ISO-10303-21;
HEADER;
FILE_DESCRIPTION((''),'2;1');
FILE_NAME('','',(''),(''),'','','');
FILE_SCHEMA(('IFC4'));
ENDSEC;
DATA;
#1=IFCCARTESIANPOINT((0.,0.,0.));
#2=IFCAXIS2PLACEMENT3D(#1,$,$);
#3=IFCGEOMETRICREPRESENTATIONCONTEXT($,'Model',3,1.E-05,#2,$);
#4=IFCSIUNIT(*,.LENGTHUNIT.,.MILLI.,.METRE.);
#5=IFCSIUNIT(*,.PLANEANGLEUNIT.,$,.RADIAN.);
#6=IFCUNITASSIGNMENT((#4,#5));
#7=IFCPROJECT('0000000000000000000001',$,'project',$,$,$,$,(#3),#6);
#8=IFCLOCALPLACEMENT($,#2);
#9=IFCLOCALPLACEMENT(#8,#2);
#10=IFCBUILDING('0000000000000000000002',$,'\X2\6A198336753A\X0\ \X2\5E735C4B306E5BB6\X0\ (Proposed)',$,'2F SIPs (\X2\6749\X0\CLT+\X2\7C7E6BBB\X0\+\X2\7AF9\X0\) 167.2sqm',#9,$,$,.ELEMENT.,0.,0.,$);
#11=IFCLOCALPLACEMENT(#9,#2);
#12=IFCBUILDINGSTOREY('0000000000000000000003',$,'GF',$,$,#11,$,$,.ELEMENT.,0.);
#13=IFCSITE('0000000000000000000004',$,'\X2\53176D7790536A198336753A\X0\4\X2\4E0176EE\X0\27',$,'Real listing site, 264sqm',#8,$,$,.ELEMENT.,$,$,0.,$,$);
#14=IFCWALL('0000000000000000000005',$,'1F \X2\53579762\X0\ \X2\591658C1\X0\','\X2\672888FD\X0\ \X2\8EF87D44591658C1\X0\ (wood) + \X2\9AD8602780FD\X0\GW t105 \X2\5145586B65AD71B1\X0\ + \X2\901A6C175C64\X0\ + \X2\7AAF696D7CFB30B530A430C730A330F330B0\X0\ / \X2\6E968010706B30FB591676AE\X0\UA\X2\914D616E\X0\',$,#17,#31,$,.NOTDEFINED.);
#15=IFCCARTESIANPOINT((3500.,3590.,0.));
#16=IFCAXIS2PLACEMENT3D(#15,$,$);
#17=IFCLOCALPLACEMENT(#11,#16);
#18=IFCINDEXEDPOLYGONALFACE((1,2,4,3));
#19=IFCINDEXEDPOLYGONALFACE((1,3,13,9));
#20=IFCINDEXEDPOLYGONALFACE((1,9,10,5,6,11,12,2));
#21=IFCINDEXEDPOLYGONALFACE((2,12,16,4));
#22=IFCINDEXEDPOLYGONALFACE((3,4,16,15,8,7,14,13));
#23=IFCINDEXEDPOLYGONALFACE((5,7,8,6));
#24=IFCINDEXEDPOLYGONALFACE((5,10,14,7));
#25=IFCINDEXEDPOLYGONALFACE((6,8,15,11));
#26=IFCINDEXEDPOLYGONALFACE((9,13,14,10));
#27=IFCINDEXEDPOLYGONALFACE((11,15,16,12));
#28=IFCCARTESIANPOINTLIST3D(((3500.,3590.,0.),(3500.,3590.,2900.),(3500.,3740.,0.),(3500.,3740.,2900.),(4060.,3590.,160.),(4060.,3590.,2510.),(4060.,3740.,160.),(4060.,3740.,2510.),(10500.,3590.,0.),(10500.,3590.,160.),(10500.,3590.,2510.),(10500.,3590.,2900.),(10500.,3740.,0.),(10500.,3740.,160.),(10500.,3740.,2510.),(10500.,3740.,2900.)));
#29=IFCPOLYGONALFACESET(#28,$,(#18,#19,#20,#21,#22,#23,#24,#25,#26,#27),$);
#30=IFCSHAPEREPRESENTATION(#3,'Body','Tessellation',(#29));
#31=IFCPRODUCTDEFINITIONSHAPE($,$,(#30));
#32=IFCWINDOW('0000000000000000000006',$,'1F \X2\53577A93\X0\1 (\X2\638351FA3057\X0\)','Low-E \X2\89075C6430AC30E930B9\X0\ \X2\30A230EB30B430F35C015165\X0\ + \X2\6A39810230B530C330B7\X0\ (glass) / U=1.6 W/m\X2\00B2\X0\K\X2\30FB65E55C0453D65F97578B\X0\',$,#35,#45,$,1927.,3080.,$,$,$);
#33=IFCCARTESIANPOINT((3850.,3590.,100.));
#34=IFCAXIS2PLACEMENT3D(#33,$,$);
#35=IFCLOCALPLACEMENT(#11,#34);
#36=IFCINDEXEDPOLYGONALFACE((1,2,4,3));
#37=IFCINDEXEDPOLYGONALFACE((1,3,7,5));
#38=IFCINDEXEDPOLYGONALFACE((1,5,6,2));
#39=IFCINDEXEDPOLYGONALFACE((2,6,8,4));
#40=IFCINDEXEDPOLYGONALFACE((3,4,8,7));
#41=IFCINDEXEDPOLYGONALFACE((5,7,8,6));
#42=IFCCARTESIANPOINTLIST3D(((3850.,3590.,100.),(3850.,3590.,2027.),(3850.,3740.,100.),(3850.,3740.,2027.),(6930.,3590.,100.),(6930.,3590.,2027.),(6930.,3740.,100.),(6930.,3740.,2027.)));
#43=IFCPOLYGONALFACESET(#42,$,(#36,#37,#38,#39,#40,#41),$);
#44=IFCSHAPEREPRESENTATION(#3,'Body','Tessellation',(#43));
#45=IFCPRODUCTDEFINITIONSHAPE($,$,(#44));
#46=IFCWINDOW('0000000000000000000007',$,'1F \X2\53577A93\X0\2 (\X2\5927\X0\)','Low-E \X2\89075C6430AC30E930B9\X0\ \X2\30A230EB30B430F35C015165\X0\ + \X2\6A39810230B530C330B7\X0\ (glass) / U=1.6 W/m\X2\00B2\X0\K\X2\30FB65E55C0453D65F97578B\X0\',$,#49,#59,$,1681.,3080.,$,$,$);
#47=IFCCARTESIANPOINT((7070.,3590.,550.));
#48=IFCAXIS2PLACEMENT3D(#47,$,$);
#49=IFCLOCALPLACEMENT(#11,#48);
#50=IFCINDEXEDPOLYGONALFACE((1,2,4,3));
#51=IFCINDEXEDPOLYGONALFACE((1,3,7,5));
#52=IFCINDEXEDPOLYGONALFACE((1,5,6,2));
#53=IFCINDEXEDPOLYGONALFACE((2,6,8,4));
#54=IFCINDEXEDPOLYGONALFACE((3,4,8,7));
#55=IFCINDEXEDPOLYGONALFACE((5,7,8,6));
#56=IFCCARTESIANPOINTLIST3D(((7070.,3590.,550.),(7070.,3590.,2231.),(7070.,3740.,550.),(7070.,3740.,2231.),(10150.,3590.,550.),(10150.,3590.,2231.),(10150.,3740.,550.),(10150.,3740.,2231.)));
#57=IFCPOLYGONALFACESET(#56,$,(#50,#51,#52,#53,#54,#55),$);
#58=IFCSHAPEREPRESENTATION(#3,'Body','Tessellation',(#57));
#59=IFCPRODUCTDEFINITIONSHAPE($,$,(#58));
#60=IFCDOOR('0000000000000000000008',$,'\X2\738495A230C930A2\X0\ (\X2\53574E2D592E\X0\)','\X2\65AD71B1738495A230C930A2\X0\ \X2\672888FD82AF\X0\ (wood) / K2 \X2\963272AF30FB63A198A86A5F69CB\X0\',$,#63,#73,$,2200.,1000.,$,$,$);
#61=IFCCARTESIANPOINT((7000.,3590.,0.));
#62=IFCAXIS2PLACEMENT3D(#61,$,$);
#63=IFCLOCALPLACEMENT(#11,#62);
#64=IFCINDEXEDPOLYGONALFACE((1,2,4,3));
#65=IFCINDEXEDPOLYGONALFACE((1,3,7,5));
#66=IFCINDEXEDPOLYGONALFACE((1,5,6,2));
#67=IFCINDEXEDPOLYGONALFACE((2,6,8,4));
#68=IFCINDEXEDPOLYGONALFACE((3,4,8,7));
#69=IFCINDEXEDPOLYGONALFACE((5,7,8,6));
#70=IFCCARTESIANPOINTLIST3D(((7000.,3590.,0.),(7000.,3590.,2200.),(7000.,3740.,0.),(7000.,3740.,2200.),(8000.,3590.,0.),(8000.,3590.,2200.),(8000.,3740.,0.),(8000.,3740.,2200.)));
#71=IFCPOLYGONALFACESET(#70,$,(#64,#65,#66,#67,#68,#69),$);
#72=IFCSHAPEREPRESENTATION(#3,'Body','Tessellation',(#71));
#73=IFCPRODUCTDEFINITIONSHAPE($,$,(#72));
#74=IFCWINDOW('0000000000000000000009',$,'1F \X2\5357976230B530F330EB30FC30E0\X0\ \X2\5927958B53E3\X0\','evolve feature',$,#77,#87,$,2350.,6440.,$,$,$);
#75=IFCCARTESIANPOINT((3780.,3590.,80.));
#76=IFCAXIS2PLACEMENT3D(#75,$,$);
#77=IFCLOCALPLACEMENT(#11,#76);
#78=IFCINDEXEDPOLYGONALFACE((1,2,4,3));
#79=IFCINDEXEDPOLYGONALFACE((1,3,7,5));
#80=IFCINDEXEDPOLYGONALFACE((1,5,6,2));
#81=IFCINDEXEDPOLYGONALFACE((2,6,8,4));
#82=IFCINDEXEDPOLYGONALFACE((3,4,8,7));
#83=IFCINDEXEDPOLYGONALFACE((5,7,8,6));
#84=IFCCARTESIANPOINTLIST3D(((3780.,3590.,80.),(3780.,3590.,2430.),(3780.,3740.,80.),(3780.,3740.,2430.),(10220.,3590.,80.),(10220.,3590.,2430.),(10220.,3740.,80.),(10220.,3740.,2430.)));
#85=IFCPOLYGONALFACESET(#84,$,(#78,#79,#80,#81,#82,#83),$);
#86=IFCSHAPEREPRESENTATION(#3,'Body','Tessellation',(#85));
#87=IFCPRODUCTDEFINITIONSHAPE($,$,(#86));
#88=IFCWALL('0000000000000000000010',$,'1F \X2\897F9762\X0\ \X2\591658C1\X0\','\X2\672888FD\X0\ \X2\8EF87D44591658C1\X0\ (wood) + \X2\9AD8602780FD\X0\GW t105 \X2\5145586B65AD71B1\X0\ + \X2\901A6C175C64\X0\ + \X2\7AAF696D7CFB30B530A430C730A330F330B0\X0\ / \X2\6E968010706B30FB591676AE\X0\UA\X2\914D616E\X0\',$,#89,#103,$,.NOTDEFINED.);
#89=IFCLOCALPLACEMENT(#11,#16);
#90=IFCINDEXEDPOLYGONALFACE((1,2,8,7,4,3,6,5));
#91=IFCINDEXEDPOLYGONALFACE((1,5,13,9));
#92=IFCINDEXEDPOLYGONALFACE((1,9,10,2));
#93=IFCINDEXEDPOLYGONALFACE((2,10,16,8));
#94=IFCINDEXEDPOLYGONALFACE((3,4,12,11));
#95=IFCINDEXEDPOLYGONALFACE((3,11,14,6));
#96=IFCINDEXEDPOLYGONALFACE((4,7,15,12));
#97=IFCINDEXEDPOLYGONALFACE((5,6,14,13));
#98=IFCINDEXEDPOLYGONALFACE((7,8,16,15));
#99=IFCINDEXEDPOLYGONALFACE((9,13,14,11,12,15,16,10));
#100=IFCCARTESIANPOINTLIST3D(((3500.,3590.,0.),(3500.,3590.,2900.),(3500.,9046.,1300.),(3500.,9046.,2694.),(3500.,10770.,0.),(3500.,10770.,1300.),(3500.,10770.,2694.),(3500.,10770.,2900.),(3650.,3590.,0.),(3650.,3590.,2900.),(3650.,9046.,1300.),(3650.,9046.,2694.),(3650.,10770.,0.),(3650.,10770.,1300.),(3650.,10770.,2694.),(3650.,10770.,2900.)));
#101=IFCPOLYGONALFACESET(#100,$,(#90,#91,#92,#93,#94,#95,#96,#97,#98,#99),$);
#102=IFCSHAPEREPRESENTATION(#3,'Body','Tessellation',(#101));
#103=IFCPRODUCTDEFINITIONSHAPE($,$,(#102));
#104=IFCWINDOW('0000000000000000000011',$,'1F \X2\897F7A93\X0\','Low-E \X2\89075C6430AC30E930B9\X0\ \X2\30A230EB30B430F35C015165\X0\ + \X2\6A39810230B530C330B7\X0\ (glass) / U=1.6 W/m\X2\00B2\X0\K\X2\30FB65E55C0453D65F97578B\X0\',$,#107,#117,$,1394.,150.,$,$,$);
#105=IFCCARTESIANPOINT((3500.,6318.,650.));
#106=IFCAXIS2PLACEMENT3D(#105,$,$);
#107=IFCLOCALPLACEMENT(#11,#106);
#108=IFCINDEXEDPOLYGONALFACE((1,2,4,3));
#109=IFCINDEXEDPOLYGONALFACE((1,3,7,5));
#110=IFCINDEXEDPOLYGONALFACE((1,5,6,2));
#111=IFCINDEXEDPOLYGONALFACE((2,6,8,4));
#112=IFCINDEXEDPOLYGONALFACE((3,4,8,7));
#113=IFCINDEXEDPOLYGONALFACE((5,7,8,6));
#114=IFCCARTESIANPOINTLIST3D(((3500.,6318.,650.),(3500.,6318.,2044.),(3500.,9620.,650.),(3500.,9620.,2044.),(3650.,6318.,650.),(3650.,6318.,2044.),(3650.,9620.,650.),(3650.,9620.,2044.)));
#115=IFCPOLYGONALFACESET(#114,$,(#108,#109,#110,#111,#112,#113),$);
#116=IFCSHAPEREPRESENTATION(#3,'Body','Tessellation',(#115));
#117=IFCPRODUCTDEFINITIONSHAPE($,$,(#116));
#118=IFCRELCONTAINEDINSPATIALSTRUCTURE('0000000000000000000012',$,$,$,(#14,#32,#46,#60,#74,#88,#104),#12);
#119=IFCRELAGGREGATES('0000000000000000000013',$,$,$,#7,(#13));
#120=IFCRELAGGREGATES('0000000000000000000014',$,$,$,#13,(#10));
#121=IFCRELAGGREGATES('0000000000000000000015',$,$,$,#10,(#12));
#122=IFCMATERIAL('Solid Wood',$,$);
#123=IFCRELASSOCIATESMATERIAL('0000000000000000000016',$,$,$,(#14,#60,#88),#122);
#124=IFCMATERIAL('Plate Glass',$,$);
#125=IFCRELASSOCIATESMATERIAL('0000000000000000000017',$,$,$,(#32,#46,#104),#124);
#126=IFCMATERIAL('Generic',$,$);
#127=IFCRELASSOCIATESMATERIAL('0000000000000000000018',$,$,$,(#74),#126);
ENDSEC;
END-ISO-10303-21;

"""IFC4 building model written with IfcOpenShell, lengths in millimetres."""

from ifc_helpers import new_model, si_unit, frame, frame_2d, origin, place, context, project, spatial, rectangle, extrude, material, element, fill, save


model = new_model("IFC4")

# Units and contexts
model_context = context("Model", 3, precision=1e-05, world=origin())
ifc_project = project(units=[si_unit("LENGTHUNIT", "METRE", prefix="MILLI"), si_unit("PLANEANGLEUNIT", "RADIAN")], contexts=[model_context])

# Site, building, storey
site_placement = place(None, origin())
site = spatial("IfcSite", under=ifc_project, at=site_placement, Name="北海道標茶町4丁目27", ObjectType="Real listing site, 264sqm", CompositionType="ELEMENT", RefElevation=0.0)
building_placement = place(site_placement, origin())
building = spatial("IfcBuilding", under=site, at=building_placement, Name="標茶町 平屋の家 (Proposed)", ObjectType="2F SIPs (杉CLT+籾殻+竹) 167.2sqm", CompositionType="ELEMENT", ElevationOfRefHeight=0.0, ElevationOfTerrain=0.0)
storey_placement = place(building_placement, origin())
storey = spatial("IfcBuildingStorey", under=building, at=storey_placement, Name="GF", CompositionType="ELEMENT", Elevation=0.0)

# Shared definitions
ifc_material_1 = material(Name="Solid Wood")
ifc_material_2 = material(Name="Generic")

# Wall, openings, windows, door
wall_1_placement = place(storey_placement, frame((3500.0, 3590.0, 0.0)))
wall_1 = element("IfcWall", 1, at=wall_1_placement, inside=storey, material=ifc_material_1, Name="1F 南面 外壁", Description="木製 軸組外壁 (wood) + 高性能GW t105 充填断熱 + 通気層 + 窯業系サイディング / 準耐火・外皮UA配慮", PredefinedType="NOTDEFINED", context=model_context, shape_type="SweptSolid", body=[
    extrude(rectangle(XDim=7000.0, YDim=150.0, at=frame_2d((3500.0, 75.0))), frame((3500.0, 3590.0, 0.0)), (0.0, 0.0, 1.0), 2900.0),
])
opening_1_placement = place(storey_placement, frame((3850.0, 3590.0, 100.0)))
opening_1 = element("IfcOpeningElement", 2, at=opening_1_placement, cuts=wall_1, PredefinedType="NOTDEFINED", context=model_context, shape_type="SweptSolid", body=[
    extrude(rectangle(XDim=3080.0, YDim=150.0, at=frame_2d((1540.0, 75.0))), frame((3850.0, 3590.0, 100.0)), (0.0, 0.0, 1.0), 1927.0),
])
opening_2_placement = place(storey_placement, frame((7070.0, 3590.0, 550.0)))
opening_2 = element("IfcOpeningElement", 3, at=opening_2_placement, cuts=wall_1, PredefinedType="NOTDEFINED", context=model_context, shape_type="SweptSolid", body=[
    extrude(rectangle(XDim=3080.0, YDim=150.0, at=frame_2d((1540.0, 75.0))), frame((7070.0, 3590.0, 550.0)), (0.0, 0.0, 1.0), 1681.0),
])
opening_3_placement = place(storey_placement, frame((7000.0, 3590.0, 0.0)))
opening_3 = element("IfcOpeningElement", 4, at=opening_3_placement, cuts=wall_1, PredefinedType="NOTDEFINED", context=model_context, shape_type="SweptSolid", body=[
    extrude(rectangle(XDim=1000.0, YDim=150.0, at=frame_2d((500.0, 75.0))), frame((7000.0, 3590.0, 0.0)), (0.0, 0.0, 1.0), 2200.0),
])
opening_4_placement = place(storey_placement, frame((3780.0, 3590.0, 80.0)))
opening_4 = element("IfcOpeningElement", 5, at=opening_4_placement, cuts=wall_1, PredefinedType="NOTDEFINED", context=model_context, shape_type="SweptSolid", body=[
    extrude(rectangle(XDim=6440.0, YDim=150.0, at=frame_2d((3220.0, 75.0))), frame((3780.0, 3590.0, 80.0)), (0.0, 0.0, 1.0), 2350.0),
])
ifc_material_3 = material(Name="Plate Glass")
window_1_placement = place(storey_placement, frame((3850.0, 3590.0, 100.0)))
window_1 = element("IfcWindow", 6, at=window_1_placement, inside=storey, material=ifc_material_3, Name="1F 南窓1 (掃出し)", Description="Low-E 複層ガラス アルゴン封入 + 樹脂サッシ (glass) / U=1.6 W/m²K・日射取得型", OverallHeight=1927.0, OverallWidth=3080.0, context=model_context, shape_type="SweptSolid", body=[
    extrude(rectangle(XDim=3080.0, YDim=150.0, at=frame_2d((1540.0, 75.0))), frame((3850.0, 3590.0, 100.0)), (0.0, 0.0, 1.0), 1927.0),
])
fill(opening_1, window_1)
window_2_placement = place(storey_placement, frame((7070.0, 3590.0, 550.0)))
window_2 = element("IfcWindow", 7, at=window_2_placement, inside=storey, material=ifc_material_3, Name="1F 南窓2 (大)", Description="Low-E 複層ガラス アルゴン封入 + 樹脂サッシ (glass) / U=1.6 W/m²K・日射取得型", OverallHeight=1681.0, OverallWidth=3080.0, context=model_context, shape_type="SweptSolid", body=[
    extrude(rectangle(XDim=3080.0, YDim=150.0, at=frame_2d((1540.0, 75.0))), frame((7070.0, 3590.0, 550.0)), (0.0, 0.0, 1.0), 1681.0),
])
fill(opening_2, window_2)
door_placement = place(storey_placement, frame((7000.0, 3590.0, 0.0)))
door = element("IfcDoor", 8, at=door_placement, inside=storey, material=ifc_material_1, Name="玄関ドア (南中央)", Description="断熱玄関ドア 木製芯 (wood) / K2 防犯・採風機構", OverallHeight=2200.0, OverallWidth=1000.0, context=model_context, shape_type="SweptSolid", body=[
    extrude(rectangle(XDim=1000.0, YDim=150.0, at=frame_2d((500.0, 75.0))), frame((7000.0, 3590.0, 0.0)), (0.0, 0.0, 1.0), 2200.0),
])
fill(opening_3, door)
window_3_placement = place(storey_placement, frame((3780.0, 3590.0, 80.0)))
window_3 = element("IfcWindow", 9, at=window_3_placement, inside=storey, material=ifc_material_2, Name="1F 南面サンルーム 大開口", Description="evolve feature", OverallHeight=2350.0, OverallWidth=6440.0, context=model_context, shape_type="SweptSolid", body=[
    extrude(rectangle(XDim=6440.0, YDim=150.0, at=frame_2d((3220.0, 75.0))), frame((3780.0, 3590.0, 80.0)), (0.0, 0.0, 1.0), 2350.0),
])
fill(opening_4, window_3)

# Wall, opening, window
wall_2_placement = place(storey_placement, frame((3500.0, 3590.0, 0.0)))
wall_2 = element("IfcWall", 10, at=wall_2_placement, inside=storey, material=ifc_material_1, Name="1F 西面 外壁", Description="木製 軸組外壁 (wood) + 高性能GW t105 充填断熱 + 通気層 + 窯業系サイディング / 準耐火・外皮UA配慮", PredefinedType="NOTDEFINED", context=model_context, shape_type="SweptSolid", body=[
    extrude(rectangle(XDim=150.0, YDim=7180.0, at=frame_2d((75.0, 3590.0))), frame((3500.0, 3590.0, 0.0)), (0.0, 0.0, 1.0), 2900.0),
])
opening_5_placement = place(storey_placement, frame((3500.0, 6318.0, 650.0)))
opening_5 = element("IfcOpeningElement", 11, at=opening_5_placement, cuts=wall_2, PredefinedType="NOTDEFINED", context=model_context, shape_type="SweptSolid", body=[
    extrude(rectangle(XDim=150.0, YDim=3302.0, at=frame_2d((75.0, 1651.0))), frame((3500.0, 6318.0, 650.0)), (0.0, 0.0, 1.0), 1394.0),
])
window_4_placement = place(storey_placement, frame((3500.0, 6318.0, 650.0)))
window_4 = element("IfcWindow", 12, at=window_4_placement, inside=storey, material=ifc_material_3, Name="1F 西窓", Description="Low-E 複層ガラス アルゴン封入 + 樹脂サッシ (glass) / U=1.6 W/m²K・日射取得型", OverallHeight=1394.0, OverallWidth=150.0, context=model_context, shape_type="SweptSolid", body=[
    extrude(rectangle(XDim=150.0, YDim=3302.0, at=frame_2d((75.0, 1651.0))), frame((3500.0, 6318.0, 650.0)), (0.0, 0.0, 1.0), 1394.0),
])
fill(opening_5, window_4)

save(model, "model.ifc")
